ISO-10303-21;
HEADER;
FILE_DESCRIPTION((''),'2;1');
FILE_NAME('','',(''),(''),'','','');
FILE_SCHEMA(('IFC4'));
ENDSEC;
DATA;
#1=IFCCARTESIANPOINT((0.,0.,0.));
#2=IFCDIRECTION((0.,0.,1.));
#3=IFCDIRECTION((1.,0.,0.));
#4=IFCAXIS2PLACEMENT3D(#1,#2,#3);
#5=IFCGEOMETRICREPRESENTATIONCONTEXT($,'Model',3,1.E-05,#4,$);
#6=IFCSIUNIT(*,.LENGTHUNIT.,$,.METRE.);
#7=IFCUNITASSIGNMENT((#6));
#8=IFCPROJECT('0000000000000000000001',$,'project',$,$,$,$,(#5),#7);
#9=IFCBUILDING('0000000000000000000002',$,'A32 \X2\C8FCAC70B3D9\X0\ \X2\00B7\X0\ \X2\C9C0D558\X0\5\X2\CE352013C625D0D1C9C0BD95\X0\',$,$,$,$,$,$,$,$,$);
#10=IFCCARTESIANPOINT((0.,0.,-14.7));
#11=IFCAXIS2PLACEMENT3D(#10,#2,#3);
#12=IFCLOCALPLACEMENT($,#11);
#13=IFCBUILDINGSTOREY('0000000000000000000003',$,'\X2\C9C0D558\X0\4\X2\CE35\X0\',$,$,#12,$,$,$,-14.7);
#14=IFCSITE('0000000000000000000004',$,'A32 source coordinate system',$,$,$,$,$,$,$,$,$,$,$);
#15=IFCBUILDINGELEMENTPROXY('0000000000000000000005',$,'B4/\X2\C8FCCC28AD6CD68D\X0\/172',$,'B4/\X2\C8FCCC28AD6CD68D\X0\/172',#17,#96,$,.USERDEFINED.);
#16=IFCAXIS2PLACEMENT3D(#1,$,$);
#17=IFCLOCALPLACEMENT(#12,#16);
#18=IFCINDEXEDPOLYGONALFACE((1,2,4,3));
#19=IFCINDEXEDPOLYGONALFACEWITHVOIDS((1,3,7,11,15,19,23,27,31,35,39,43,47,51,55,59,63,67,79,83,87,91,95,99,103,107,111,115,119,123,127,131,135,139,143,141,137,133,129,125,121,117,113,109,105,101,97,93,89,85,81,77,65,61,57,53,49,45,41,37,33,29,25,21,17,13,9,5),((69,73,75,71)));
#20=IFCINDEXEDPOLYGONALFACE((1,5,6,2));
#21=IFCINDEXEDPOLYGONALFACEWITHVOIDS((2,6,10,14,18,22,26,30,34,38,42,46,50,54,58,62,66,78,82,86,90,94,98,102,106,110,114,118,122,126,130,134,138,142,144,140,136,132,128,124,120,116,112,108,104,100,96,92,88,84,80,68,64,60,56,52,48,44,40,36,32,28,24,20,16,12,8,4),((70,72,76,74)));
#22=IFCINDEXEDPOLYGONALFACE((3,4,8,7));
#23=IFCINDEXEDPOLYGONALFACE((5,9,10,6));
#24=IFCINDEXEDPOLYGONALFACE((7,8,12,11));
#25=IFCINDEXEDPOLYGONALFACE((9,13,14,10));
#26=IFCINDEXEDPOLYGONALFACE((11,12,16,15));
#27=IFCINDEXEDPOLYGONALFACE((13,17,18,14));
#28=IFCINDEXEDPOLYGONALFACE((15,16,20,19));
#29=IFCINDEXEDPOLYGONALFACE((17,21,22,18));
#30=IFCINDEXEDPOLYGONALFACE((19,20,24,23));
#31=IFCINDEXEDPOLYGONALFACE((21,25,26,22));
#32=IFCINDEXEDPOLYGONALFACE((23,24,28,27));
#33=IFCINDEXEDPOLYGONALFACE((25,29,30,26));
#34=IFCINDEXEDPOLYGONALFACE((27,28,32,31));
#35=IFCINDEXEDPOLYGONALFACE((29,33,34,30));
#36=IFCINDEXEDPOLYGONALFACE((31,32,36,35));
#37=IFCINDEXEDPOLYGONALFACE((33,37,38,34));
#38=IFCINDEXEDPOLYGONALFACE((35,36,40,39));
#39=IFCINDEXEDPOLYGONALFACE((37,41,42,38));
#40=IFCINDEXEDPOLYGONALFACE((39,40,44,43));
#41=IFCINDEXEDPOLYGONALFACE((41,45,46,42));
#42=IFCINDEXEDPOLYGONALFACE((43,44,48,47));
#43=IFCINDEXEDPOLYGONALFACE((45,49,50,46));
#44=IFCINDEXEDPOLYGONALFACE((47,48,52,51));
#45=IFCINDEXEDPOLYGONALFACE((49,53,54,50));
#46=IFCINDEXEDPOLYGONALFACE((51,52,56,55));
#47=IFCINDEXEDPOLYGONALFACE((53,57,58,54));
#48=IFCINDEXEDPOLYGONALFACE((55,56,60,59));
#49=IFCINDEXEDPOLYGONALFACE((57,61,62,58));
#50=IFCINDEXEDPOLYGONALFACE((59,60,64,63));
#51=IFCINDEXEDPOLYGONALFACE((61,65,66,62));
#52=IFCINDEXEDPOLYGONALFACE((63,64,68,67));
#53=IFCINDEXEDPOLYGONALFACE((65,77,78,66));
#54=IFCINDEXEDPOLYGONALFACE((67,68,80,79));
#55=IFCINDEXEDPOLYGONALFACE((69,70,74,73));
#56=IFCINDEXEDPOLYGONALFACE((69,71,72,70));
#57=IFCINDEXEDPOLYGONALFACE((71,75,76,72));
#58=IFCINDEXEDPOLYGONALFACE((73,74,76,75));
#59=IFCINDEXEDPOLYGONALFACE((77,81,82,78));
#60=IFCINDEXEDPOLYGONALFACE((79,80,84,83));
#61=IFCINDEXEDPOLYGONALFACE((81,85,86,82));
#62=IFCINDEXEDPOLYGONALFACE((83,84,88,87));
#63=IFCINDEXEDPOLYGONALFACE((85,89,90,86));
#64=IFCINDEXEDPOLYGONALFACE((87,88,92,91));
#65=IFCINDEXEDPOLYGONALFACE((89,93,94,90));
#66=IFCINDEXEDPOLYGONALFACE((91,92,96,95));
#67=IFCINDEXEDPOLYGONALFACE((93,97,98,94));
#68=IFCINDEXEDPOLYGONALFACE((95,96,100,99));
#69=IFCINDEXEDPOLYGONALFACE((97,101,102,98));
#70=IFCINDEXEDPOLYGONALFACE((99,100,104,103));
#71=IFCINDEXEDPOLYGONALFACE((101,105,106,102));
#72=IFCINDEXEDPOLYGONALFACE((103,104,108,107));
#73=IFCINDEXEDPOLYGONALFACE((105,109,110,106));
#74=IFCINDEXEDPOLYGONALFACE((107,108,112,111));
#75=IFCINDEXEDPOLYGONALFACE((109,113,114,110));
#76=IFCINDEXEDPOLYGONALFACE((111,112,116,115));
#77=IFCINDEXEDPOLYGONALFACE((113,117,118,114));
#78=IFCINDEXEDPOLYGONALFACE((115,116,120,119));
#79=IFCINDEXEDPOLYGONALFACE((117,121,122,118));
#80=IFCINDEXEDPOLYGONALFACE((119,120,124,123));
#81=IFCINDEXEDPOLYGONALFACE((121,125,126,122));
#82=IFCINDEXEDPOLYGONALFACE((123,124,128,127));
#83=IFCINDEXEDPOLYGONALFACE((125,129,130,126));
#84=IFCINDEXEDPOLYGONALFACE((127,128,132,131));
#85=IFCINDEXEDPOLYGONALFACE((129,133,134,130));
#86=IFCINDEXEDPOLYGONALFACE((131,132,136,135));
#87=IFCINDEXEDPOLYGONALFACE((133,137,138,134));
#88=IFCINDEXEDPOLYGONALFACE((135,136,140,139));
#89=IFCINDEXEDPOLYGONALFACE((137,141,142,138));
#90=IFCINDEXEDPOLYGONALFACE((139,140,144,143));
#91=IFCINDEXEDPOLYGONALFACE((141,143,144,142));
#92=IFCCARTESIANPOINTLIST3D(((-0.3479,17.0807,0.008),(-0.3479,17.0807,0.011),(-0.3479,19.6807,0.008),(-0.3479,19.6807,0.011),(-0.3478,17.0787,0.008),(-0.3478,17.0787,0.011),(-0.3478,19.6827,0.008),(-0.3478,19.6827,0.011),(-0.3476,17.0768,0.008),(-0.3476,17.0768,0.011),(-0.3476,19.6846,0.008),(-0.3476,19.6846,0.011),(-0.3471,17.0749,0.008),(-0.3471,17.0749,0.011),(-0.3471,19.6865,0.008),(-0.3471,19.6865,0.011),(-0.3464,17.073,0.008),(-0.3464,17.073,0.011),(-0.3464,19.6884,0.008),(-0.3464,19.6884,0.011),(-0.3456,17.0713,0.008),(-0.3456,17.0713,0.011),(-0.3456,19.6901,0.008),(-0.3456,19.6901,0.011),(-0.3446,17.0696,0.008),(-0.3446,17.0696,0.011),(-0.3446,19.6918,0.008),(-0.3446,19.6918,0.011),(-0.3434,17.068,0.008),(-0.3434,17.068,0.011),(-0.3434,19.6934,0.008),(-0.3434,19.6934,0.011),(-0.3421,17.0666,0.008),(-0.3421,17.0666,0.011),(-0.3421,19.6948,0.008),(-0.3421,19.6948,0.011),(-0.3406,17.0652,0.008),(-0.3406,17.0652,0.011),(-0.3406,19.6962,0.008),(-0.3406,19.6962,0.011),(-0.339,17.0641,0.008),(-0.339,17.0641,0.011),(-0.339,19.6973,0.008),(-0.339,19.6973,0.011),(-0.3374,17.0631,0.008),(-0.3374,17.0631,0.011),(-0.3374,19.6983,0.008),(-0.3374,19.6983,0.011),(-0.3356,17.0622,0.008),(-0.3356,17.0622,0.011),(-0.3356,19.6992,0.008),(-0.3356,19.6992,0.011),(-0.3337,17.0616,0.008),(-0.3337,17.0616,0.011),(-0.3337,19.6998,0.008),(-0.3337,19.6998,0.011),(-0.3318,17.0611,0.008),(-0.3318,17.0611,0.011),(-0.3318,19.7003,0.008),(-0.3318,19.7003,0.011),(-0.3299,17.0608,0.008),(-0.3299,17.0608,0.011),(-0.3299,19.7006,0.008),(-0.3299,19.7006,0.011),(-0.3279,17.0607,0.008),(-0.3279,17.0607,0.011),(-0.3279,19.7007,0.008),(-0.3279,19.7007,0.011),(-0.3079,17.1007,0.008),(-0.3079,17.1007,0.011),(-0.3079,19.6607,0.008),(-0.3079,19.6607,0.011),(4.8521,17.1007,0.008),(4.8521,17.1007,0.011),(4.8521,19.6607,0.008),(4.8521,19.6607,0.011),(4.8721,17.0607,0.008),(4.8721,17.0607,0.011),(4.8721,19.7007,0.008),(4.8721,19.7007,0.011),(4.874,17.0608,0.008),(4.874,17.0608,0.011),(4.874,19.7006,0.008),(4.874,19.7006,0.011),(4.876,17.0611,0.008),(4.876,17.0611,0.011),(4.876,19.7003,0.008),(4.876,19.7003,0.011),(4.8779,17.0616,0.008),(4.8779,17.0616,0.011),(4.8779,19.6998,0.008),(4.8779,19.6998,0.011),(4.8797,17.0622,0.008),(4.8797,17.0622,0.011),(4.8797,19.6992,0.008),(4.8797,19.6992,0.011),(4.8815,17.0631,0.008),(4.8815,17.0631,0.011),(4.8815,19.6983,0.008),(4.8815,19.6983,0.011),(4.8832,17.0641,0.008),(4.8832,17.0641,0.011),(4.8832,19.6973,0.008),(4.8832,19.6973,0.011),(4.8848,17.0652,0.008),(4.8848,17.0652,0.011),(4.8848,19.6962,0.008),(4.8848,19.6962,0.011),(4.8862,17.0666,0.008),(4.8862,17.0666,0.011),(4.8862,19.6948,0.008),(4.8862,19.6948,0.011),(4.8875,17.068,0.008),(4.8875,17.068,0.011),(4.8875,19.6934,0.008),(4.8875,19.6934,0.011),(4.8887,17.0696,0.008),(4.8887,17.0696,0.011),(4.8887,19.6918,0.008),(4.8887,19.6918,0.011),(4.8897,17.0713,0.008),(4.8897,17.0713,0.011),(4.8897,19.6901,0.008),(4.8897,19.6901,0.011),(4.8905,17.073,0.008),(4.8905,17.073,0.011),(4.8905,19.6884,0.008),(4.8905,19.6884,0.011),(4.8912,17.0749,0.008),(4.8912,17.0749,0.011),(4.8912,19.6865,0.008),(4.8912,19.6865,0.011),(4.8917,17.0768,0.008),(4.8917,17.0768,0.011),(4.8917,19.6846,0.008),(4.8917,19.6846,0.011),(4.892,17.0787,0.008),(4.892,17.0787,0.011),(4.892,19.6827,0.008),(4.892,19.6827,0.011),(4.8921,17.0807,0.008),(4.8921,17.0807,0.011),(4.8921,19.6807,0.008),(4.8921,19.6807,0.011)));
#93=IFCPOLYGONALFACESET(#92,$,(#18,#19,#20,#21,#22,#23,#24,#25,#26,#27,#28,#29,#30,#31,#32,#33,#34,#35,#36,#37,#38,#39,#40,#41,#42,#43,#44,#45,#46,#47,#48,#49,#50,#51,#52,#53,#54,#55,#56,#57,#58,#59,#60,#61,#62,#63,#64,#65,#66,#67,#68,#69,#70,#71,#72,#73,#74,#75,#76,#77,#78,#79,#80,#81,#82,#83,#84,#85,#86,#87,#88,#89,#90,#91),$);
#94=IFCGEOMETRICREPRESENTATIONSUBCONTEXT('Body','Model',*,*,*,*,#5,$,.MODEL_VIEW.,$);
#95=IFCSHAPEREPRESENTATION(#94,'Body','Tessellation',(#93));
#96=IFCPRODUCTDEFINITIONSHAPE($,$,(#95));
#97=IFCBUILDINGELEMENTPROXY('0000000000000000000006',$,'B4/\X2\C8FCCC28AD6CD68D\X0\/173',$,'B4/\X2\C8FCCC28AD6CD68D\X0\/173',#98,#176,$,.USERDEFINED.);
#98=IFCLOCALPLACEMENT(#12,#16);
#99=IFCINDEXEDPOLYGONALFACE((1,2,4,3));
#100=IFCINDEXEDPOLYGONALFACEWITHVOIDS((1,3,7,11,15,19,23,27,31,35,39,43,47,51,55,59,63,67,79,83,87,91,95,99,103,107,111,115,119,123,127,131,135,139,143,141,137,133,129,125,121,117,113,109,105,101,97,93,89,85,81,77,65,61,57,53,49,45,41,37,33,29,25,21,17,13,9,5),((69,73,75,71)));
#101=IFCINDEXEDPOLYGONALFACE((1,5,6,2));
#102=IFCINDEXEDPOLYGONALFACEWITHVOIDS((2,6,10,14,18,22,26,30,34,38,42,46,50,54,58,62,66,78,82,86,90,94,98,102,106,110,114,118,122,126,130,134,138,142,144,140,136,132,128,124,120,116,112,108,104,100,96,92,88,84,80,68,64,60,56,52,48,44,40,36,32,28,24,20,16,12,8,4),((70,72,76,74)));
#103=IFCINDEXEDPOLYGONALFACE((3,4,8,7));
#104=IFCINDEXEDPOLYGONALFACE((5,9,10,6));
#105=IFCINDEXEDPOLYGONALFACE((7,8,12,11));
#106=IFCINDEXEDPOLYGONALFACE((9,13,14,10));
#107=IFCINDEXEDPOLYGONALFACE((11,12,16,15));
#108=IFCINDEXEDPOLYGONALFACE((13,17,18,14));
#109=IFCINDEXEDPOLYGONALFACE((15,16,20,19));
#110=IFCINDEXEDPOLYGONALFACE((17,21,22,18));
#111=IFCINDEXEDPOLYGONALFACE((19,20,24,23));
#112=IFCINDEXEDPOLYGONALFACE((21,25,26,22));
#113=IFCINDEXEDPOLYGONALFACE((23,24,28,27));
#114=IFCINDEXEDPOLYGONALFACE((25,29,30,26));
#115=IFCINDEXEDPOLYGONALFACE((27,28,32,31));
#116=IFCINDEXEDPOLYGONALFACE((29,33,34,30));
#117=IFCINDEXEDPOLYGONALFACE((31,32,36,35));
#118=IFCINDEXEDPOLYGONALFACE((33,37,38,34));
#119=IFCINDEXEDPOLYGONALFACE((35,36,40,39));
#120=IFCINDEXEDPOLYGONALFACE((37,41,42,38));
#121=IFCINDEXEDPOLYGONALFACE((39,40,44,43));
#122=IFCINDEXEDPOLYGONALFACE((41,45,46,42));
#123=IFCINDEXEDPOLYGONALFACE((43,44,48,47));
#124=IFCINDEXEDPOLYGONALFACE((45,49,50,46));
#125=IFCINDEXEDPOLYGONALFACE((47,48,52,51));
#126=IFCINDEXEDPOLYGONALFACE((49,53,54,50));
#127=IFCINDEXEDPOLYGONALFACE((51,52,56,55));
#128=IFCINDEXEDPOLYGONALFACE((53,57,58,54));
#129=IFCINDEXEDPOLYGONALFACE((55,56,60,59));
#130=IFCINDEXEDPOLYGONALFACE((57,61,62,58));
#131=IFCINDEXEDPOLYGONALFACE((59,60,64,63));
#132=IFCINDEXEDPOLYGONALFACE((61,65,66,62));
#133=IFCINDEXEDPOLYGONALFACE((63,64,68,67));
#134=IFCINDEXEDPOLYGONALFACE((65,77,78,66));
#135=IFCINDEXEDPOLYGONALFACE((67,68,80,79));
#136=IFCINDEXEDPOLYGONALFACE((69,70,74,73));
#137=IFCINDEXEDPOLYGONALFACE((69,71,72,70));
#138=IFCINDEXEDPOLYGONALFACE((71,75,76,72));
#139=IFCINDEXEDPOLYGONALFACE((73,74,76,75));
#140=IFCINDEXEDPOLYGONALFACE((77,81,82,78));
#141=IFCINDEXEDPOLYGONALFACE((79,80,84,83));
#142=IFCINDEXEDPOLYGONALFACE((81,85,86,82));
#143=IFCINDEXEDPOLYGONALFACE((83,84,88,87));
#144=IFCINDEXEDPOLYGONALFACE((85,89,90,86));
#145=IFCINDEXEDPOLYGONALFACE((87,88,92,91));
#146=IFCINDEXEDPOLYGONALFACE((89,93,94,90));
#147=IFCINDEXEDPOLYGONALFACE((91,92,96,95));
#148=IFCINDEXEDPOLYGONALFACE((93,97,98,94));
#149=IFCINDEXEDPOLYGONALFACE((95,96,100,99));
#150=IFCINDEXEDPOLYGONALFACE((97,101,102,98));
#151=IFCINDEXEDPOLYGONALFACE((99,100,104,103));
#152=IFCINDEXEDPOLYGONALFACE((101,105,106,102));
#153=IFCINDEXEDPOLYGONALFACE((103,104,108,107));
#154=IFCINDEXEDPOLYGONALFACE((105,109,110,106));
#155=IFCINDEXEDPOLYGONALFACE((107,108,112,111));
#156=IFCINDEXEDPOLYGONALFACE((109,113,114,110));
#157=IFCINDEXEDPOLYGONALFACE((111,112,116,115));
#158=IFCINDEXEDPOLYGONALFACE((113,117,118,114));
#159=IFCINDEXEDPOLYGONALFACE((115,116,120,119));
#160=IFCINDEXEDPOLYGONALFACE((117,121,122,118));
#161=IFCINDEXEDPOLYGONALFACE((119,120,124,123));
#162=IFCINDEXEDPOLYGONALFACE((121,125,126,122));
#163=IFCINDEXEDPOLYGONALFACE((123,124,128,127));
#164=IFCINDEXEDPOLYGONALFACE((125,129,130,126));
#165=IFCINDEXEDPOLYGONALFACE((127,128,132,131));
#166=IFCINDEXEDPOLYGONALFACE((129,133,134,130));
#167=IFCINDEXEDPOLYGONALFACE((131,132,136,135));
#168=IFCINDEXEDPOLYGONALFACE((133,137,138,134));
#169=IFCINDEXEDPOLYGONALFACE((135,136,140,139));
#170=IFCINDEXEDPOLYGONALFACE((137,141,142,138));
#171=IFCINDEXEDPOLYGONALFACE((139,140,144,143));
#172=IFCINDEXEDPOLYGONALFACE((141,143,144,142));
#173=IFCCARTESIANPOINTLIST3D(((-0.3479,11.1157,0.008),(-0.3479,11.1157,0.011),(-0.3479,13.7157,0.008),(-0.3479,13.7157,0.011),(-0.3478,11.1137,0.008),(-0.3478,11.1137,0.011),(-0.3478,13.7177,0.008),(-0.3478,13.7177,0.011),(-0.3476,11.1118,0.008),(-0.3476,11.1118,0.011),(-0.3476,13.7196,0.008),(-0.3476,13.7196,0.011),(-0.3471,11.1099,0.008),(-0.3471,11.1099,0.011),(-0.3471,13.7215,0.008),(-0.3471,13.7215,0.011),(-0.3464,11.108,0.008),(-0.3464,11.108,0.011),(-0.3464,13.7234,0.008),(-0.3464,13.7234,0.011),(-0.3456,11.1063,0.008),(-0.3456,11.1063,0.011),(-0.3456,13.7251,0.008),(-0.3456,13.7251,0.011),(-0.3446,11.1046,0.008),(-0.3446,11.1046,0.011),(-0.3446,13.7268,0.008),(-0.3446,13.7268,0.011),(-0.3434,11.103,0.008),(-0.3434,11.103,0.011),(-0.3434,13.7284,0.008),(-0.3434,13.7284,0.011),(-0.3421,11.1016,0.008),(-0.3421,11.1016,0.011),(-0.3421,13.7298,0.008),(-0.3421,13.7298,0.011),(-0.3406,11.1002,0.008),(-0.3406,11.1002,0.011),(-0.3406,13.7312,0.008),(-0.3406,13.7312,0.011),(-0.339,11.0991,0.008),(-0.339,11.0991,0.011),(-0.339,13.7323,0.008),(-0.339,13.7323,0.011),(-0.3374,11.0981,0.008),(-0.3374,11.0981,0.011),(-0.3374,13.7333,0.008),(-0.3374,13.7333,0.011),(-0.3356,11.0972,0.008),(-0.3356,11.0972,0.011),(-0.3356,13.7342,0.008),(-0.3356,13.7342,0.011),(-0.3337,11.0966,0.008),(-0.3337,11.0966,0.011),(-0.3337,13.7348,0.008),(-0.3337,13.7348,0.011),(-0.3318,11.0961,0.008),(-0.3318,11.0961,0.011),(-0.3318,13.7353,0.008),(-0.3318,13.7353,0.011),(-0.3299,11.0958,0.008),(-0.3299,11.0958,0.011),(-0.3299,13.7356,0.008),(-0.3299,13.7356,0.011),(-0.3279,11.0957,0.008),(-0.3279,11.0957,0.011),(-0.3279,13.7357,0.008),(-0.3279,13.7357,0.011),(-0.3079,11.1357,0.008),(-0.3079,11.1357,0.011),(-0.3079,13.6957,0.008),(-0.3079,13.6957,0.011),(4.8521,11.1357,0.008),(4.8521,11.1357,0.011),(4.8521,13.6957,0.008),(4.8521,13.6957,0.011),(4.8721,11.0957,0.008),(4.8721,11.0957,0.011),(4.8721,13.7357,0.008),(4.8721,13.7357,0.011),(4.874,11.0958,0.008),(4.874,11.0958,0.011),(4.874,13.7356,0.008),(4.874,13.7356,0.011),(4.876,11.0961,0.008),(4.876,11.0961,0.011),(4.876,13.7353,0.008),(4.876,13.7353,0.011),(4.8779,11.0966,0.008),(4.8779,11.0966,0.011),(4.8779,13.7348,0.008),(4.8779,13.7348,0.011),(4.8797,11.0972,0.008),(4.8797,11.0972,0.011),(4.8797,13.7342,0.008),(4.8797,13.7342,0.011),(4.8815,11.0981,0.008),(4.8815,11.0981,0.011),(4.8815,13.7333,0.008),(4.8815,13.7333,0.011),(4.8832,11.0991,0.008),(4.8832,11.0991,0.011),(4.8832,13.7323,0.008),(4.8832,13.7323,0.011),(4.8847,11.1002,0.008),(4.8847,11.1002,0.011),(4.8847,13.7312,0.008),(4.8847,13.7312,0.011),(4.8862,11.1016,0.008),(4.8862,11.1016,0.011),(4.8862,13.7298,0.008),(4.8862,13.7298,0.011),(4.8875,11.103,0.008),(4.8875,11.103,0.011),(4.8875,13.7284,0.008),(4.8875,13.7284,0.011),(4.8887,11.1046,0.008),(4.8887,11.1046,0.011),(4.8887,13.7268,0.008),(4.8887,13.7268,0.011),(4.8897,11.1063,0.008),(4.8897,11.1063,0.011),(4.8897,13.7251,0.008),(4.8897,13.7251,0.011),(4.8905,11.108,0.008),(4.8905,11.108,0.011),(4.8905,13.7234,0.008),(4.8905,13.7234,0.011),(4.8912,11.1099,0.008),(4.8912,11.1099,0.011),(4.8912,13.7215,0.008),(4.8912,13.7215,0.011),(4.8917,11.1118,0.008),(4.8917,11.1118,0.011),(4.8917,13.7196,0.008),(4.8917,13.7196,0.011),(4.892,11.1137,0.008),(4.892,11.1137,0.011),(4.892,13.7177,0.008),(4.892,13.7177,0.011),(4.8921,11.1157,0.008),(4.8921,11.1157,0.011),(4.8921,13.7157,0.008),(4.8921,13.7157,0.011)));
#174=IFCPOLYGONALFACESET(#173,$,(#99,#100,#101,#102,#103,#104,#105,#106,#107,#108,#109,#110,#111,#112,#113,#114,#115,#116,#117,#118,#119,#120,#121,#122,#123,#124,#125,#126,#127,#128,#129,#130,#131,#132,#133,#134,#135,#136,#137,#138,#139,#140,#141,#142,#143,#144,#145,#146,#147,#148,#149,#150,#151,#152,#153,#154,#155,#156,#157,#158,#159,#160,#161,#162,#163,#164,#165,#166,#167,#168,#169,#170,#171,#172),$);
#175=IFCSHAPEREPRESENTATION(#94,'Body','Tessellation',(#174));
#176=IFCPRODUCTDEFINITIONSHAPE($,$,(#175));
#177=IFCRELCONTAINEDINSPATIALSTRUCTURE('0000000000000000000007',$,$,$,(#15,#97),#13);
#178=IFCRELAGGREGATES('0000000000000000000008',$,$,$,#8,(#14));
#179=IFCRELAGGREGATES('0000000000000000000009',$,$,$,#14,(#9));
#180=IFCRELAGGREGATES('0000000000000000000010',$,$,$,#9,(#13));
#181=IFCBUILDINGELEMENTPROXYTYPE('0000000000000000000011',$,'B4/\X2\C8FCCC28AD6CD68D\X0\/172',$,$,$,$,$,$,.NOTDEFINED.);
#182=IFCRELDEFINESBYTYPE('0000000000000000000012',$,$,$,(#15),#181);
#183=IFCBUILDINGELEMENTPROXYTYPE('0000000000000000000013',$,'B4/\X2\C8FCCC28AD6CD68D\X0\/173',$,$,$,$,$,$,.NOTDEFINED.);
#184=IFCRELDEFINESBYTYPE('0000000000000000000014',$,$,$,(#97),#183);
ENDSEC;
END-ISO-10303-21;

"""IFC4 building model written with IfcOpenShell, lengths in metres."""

from ifc_helpers import new_model, si_unit, frame, origin, origin_with_axes, place, context, subcontext, project, spatial, polyline, outline, extrude, source, transform, mapped, type_object, type_shapes, element, save


model = new_model("IFC4")

# Units and contexts
model_context = context("Model", 3, precision=1e-05, world=origin_with_axes())
body_context = subcontext(model_context, "Body", "Model", "MODEL_VIEW")
ifc_project = project(units=[si_unit("LENGTHUNIT", "METRE")], contexts=[model_context])

# Site, building, storey
site = spatial("IfcSite", under=ifc_project, Name="A32 source coordinate system")
building = spatial("IfcBuilding", under=site, Name="A32 주거동 · 지하5층–옥탑지붕")
storey_placement = place(None, frame((0.0, 0.0, -14.7), z_axis=(0.0, 0.0, 1.0), x_axis=(1.0, 0.0, 0.0)))
storey = spatial("IfcBuildingStorey", under=building, at=storey_placement, Name="지하4층", Elevation=-14.7)

# Building element proxies
building_element_proxy_type_1 = type_object("IfcBuildingElementProxyType", Name="B4/주차구획/172", PredefinedType="NOTDEFINED")
shared_shape_1 = source(origin(), body_context, "Body", "SweptSolid", [
    extrude(outline(polyline([(-0.3279, 17.0607), (-0.3299, 17.0608), (-0.3318, 17.0611), (-0.3337, 17.0616), (-0.3356, 17.0622), (-0.3374, 17.0631), (-0.339, 17.0641), (-0.3406, 17.0652), (-0.3421, 17.0666), (-0.3434, 17.068), (-0.3446, 17.0696), (-0.3456, 17.0713), (-0.3464, 17.073), (-0.3471, 17.0749), (-0.3476, 17.0768), (-0.3478, 17.0787), (-0.3479, 17.0807), (-0.3479, 19.6807), (-0.3478, 19.6827), (-0.3476, 19.6846), (-0.3471, 19.6865), (-0.3464, 19.6884), (-0.3456, 19.6901), (-0.3446, 19.6918), (-0.3434, 19.6934), (-0.3421, 19.6948), (-0.3406, 19.6962), (-0.339, 19.6973), (-0.3374, 19.6983), (-0.3356, 19.6992), (-0.3337, 19.6998), (-0.3318, 19.7003), (-0.3299, 19.7006), (-0.3279, 19.7007), (4.8721, 19.7007), (4.874, 19.7006), (4.876, 19.7003), (4.8779, 19.6998), (4.8797, 19.6992), (4.8815, 19.6983), (4.8832, 19.6973), (4.8848, 19.6962), (4.8862, 19.6948), (4.8875, 19.6934), (4.8887, 19.6918), (4.8897, 19.6901), (4.8905, 19.6884), (4.8912, 19.6865), (4.8917, 19.6846), (4.892, 19.6827), (4.8921, 19.6807), (4.8921, 17.0807), (4.892, 17.0787), (4.8917, 17.0768), (4.8912, 17.0749), (4.8905, 17.073), (4.8897, 17.0713), (4.8887, 17.0696), (4.8875, 17.068), (4.8862, 17.0666), (4.8848, 17.0652), (4.8832, 17.0641), (4.8815, 17.0631), (4.8797, 17.0622), (4.8779, 17.0616), (4.876, 17.0611), (4.874, 17.0608), (4.8721, 17.0607), (-0.3279, 17.0607)]), holes=[polyline([(-0.3079, 17.1007), (4.8521, 17.1007), (4.8521, 19.6607), (-0.3079, 19.6607), (-0.3079, 17.1007)])]), frame((0.0, 0.0, 0.008)), (0.0, 0.0, 1.0), 0.003),
])
type_shapes(building_element_proxy_type_1, [shared_shape_1])
proxy_1_placement = place(storey_placement, origin_with_axes())
element("IfcBuildingElementProxy", 1, at=proxy_1_placement, inside=storey, type_object=building_element_proxy_type_1, Name="B4/주차구획/172", ObjectType="B4/주차구획/172", PredefinedType="USERDEFINED", context=body_context, shape_type="MappedRepresentation", body=[
    mapped(shared_shape_1, transform((0.0, 0.0, 0.0), scale=1.0)),
])
building_element_proxy_type_2 = type_object("IfcBuildingElementProxyType", Name="B4/주차구획/173", PredefinedType="NOTDEFINED")
shared_shape_2 = source(origin(), body_context, "Body", "SweptSolid", [
    extrude(outline(polyline([(-0.3279, 11.0957), (-0.3299, 11.0958), (-0.3318, 11.0961), (-0.3337, 11.0966), (-0.3356, 11.0972), (-0.3374, 11.0981), (-0.339, 11.0991), (-0.3406, 11.1002), (-0.3421, 11.1016), (-0.3434, 11.103), (-0.3446, 11.1046), (-0.3456, 11.1063), (-0.3464, 11.108), (-0.3471, 11.1099), (-0.3476, 11.1118), (-0.3478, 11.1137), (-0.3479, 11.1157), (-0.3479, 13.7157), (-0.3478, 13.7177), (-0.3476, 13.7196), (-0.3471, 13.7215), (-0.3464, 13.7234), (-0.3456, 13.7251), (-0.3446, 13.7268), (-0.3434, 13.7284), (-0.3421, 13.7298), (-0.3406, 13.7312), (-0.339, 13.7323), (-0.3374, 13.7333), (-0.3356, 13.7342), (-0.3337, 13.7348), (-0.3318, 13.7353), (-0.3299, 13.7356), (-0.3279, 13.7357), (4.8721, 13.7357), (4.874, 13.7356), (4.876, 13.7353), (4.8779, 13.7348), (4.8797, 13.7342), (4.8815, 13.7333), (4.8832, 13.7323), (4.8847, 13.7312), (4.8862, 13.7298), (4.8875, 13.7284), (4.8887, 13.7268), (4.8897, 13.7251), (4.8905, 13.7234), (4.8912, 13.7215), (4.8917, 13.7196), (4.892, 13.7177), (4.8921, 13.7157), (4.8921, 11.1157), (4.892, 11.1137), (4.8917, 11.1118), (4.8912, 11.1099), (4.8905, 11.108), (4.8897, 11.1063), (4.8887, 11.1046), (4.8875, 11.103), (4.8862, 11.1016), (4.8847, 11.1002), (4.8832, 11.0991), (4.8815, 11.0981), (4.8797, 11.0972), (4.8779, 11.0966), (4.876, 11.0961), (4.874, 11.0958), (4.8721, 11.0957), (-0.3279, 11.0957)]), holes=[polyline([(-0.3079, 11.1357), (4.8521, 11.1357), (4.8521, 13.6957), (-0.3079, 13.6957), (-0.3079, 11.1357)])]), frame((0.0, 0.0, 0.008)), (0.0, 0.0, 1.0), 0.003),
])
type_shapes(building_element_proxy_type_2, [shared_shape_2])
proxy_2_placement = place(storey_placement, origin_with_axes())
element("IfcBuildingElementProxy", 2, at=proxy_2_placement, inside=storey, type_object=building_element_proxy_type_2, Name="B4/주차구획/173", ObjectType="B4/주차구획/173", PredefinedType="USERDEFINED", context=body_context, shape_type="MappedRepresentation", body=[
    mapped(shared_shape_2, transform((0.0, 0.0, 0.0), scale=1.0)),
])

save(model, "model.ifc")
